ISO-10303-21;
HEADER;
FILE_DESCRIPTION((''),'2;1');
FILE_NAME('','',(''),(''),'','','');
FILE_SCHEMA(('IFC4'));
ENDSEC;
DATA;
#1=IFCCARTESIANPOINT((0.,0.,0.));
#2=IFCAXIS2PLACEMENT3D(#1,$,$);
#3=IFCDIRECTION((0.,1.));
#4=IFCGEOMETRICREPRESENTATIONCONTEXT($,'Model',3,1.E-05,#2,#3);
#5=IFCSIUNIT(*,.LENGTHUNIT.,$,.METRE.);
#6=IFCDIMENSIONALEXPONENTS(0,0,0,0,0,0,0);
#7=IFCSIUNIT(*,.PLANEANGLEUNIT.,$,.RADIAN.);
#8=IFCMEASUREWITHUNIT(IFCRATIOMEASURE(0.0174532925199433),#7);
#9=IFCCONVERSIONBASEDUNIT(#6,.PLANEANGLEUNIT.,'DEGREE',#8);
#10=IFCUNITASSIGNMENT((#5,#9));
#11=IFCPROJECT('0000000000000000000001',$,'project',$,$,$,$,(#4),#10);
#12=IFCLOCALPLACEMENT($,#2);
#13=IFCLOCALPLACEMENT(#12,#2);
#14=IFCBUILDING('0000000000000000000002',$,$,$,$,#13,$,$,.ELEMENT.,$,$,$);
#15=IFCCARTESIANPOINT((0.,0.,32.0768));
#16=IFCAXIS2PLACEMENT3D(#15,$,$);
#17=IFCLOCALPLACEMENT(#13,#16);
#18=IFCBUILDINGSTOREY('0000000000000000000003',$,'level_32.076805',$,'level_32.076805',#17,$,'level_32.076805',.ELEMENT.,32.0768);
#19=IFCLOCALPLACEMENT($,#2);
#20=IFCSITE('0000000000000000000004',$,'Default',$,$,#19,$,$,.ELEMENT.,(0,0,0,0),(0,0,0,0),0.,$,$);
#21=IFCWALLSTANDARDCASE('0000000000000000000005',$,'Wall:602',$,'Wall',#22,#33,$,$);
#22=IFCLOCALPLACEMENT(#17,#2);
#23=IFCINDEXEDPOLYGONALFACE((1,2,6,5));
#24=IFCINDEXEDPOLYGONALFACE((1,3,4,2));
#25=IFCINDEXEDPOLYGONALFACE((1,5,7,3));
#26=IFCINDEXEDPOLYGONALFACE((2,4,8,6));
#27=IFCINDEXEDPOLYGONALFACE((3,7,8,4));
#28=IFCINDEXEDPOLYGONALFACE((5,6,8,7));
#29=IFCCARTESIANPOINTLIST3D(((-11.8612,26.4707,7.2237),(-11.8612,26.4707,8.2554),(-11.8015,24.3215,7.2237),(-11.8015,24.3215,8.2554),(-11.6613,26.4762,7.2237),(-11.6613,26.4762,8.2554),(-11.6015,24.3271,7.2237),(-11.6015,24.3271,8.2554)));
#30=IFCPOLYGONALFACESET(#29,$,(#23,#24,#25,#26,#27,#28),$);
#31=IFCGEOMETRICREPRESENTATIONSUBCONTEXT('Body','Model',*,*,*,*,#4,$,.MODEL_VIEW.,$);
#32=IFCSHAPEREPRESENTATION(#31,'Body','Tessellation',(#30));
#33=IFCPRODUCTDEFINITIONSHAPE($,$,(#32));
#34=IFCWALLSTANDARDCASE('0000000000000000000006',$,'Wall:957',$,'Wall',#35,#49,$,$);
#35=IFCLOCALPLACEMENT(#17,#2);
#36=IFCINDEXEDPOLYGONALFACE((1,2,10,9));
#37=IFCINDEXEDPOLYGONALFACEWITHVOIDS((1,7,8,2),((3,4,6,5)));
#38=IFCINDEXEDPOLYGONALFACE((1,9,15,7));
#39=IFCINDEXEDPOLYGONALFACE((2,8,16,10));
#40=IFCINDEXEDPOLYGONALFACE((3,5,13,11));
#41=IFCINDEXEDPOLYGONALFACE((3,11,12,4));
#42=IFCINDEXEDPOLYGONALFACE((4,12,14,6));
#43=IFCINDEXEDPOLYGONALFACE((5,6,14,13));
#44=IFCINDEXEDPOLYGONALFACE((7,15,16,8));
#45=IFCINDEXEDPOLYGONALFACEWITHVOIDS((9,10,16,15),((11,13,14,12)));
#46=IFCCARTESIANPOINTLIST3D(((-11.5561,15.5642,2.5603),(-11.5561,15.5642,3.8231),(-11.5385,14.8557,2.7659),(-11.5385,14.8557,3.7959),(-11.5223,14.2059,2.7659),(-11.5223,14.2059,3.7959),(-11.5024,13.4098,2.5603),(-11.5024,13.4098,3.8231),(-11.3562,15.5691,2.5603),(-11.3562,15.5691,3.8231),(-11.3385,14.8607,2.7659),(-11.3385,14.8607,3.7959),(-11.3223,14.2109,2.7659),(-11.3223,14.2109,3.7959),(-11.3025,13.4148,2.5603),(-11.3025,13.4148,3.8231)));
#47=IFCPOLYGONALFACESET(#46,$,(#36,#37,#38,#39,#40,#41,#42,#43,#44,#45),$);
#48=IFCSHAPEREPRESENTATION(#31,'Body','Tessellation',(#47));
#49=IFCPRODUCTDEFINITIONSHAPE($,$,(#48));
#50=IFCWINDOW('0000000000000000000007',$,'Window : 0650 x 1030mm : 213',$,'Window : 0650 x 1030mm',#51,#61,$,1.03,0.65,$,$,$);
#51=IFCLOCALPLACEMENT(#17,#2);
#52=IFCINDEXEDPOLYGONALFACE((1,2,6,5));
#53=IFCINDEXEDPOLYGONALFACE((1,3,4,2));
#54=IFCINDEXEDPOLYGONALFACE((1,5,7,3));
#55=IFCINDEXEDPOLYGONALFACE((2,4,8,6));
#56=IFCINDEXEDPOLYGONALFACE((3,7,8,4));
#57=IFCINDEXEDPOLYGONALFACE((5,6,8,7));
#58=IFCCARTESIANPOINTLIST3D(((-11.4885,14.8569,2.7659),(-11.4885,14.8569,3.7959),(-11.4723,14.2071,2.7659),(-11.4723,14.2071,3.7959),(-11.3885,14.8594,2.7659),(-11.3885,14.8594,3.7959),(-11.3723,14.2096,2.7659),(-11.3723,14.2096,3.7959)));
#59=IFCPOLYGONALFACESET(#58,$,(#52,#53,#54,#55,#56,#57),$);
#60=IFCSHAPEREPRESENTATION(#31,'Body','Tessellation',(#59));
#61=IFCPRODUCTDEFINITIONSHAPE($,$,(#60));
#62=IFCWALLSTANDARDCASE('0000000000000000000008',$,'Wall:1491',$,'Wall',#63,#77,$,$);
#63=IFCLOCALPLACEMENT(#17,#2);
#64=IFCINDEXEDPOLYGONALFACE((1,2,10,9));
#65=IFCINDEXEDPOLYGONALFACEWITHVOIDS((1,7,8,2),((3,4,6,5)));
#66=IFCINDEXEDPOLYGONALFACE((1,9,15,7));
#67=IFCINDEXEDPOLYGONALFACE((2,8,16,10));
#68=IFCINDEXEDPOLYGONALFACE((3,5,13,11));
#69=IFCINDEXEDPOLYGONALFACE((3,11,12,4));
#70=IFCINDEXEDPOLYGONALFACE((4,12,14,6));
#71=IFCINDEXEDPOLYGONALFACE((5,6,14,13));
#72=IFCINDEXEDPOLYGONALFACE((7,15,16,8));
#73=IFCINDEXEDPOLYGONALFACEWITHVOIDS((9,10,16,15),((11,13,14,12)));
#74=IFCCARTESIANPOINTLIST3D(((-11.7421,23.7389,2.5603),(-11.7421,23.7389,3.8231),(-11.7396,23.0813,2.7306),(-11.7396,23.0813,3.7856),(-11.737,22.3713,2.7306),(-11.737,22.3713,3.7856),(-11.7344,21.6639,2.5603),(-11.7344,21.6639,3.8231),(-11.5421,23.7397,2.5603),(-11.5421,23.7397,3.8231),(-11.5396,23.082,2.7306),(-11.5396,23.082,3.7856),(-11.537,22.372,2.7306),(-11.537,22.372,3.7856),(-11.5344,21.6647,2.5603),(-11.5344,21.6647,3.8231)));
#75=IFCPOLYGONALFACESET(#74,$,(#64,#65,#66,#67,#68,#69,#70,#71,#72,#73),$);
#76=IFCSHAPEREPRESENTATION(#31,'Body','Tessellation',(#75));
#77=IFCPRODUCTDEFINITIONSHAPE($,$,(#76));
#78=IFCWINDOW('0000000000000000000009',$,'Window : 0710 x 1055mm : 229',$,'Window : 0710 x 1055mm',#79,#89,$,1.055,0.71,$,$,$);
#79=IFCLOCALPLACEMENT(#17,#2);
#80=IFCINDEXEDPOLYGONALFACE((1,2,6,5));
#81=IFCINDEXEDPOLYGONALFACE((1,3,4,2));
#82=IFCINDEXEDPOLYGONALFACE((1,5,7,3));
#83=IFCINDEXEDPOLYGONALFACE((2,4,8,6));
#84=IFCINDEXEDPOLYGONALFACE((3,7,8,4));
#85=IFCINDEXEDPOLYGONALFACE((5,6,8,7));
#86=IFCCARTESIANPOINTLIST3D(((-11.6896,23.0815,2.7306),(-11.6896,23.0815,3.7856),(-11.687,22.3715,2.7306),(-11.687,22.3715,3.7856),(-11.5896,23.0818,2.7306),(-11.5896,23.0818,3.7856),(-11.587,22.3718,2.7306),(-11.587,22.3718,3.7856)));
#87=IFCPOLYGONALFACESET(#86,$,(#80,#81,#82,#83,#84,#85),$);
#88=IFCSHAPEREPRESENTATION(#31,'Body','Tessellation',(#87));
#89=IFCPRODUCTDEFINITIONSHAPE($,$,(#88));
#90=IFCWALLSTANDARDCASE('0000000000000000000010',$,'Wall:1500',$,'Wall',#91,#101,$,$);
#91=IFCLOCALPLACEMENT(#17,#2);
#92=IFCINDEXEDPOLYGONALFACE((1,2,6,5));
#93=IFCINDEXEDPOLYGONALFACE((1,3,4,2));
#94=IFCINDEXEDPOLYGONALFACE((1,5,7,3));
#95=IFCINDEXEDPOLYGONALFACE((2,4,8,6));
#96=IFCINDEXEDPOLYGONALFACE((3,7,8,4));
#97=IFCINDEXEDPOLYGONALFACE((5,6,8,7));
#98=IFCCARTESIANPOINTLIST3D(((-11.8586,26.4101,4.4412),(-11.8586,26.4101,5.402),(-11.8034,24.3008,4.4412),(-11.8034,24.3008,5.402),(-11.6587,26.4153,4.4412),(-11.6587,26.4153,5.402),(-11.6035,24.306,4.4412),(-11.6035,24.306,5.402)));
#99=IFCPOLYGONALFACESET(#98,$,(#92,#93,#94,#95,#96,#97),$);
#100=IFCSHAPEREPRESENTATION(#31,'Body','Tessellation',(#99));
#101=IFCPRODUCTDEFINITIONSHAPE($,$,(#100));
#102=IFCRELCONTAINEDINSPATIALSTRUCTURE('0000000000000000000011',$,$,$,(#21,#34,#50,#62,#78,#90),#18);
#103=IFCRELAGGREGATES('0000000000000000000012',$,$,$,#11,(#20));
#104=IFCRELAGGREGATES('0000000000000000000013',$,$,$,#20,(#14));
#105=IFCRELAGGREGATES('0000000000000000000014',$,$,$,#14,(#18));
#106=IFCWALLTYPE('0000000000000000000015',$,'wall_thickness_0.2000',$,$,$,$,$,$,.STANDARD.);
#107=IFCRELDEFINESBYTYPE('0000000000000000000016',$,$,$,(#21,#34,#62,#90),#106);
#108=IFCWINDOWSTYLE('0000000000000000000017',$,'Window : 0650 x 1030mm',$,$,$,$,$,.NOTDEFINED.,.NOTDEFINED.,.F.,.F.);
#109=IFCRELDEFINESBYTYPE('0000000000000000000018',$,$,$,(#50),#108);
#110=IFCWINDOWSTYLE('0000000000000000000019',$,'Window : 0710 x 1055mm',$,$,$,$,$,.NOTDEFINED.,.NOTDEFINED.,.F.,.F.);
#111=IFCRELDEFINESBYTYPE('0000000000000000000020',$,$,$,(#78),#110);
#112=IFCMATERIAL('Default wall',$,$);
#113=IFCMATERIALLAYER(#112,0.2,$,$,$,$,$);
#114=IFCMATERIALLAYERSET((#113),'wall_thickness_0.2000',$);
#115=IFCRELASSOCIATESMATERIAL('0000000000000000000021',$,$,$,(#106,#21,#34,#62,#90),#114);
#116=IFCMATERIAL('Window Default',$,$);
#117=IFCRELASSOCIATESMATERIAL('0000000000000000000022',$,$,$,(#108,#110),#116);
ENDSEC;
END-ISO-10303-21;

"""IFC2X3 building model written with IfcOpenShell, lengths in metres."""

from ifc_helpers import new_model, entity, si_unit, converted_unit, direction, frame, frame_2d, origin, origin_2d_with_axis, place, context, subcontext, project, spatial, polyline, rectangle, outline, extrude, source, transform, mapped, material, layer, layer_set, layer_usage, type_object, type_shapes, element, fill, save


model = new_model("IFC2X3")

# Units and contexts
model_context = context("Model", 3, precision=1e-05, world=origin(), true_north=direction((0.0, 1.0)))
body_context = subcontext(model_context, "Body", "Model", "MODEL_VIEW")
ifc_project = project(units=[si_unit("LENGTHUNIT", "METRE"), converted_unit("PLANEANGLEUNIT", "DEGREE", entity("IfcRatioMeasure", 0.0174532925199433), si_unit("PLANEANGLEUNIT", "RADIAN"), dimensions=[0, 0, 0, 0, 0, 0, 0])], contexts=[model_context])

# Site, building, storey
site_placement = place(None, origin())
site = spatial("IfcSite", under=ifc_project, at=site_placement, Name="Default", CompositionType="ELEMENT", RefLatitude=(0, 0, 0, 0), RefLongitude=(0, 0, 0, 0), RefElevation=0.0)
placement_1 = place(None, origin())
building_placement = place(placement_1, origin())
building = spatial("IfcBuilding", under=site, at=building_placement, CompositionType="ELEMENT")
storey_placement = place(building_placement, frame((0.0, 0.0, 32.0768)))
storey = spatial("IfcBuildingStorey", under=building, at=storey_placement, Name="level_32.076805", ObjectType="level_32.076805", LongName="level_32.076805", CompositionType="ELEMENT", Elevation=32.0768)

# Shared definitions
ifc_material_1 = material(Name="Default wall")
ifc_layer = layer(ifc_material_1, 0.2)
ifc_layer_set = layer_set([ifc_layer], Name="wall_thickness_0.2000")
ifc_layer_usage = layer_usage(ifc_layer_set, "AXIS2", "POSITIVE", -0.1)
wall_type = type_object("IfcWallType", Name="wall_thickness_0.2000", PredefinedType="STANDARD", material=ifc_layer_set)
ifc_material_2 = material(Name="Window Default")

# Wall
placement_2 = place(building_placement, frame((0.0, 0.0, 39.3005)))
wall_1_placement = place(placement_2, frame((-11.7015, 24.3243, 0.0), z_axis=(0.0, 0.0, 1.0), x_axis=(-0.02778, 0.999614, 0.0)))
element("IfcWallStandardCase", 1, at=wall_1_placement, inside=storey, type_object=wall_type, material=ifc_layer_usage, Name="Wall:602", ObjectType="Wall", context=body_context, shape_type="SweptSolid", body=[
    extrude(outline(polyline([(2.15, -0.1), (2.15, 0.1), (0.0, 0.1), (0.0, -0.1), (2.15, -0.1)])), origin(), (0.0, 0.0, 1.0), 1.0317),
])

# Walls, openings, windows
placement_3 = place(building_placement, frame((0.0, 0.0, 34.6371)))
wall_2_placement = place(placement_3, frame((-11.4025, 13.4123, 0.0), z_axis=(0.0, 0.0, 1.0), x_axis=(-0.024917, 0.99969, 0.0)))
wall_2 = element("IfcWallStandardCase", 2, at=wall_2_placement, inside=storey, type_object=wall_type, material=ifc_layer_usage, Name="Wall:957", ObjectType="Wall", context=body_context, shape_type="SweptSolid", body=[
    extrude(outline(polyline([(2.155, -0.1), (2.155, 0.1), (0.0, 0.1), (0.0, -0.1), (2.155, -0.1)])), origin(), (0.0, 0.0, 1.0), 1.2628),
])
opening_1_placement = place(wall_2_placement, frame((0.7963, -0.1, 0.2056)))
opening_1 = element("IfcOpeningElement", 3, at=opening_1_placement, cuts=wall_2, ObjectType="Opening", context=body_context, shape_type="SweptSolid", body=[
    extrude(rectangle(XDim=0.65, YDim=1.03, at=frame_2d((0.515, 0.325), x_axis=(0.0, 1.0))), frame((0.0, 0.0, 0.0), z_axis=(0.0, 1.0, 0.0), x_axis=(0.0, 0.0, 1.0)), (0.0, 0.0, 1.0), 0.2),
])
window_style_1 = type_object("IfcWindowStyle", Name="Window : 0650 x 1030mm", ConstructionType="NOTDEFINED", OperationType="NOTDEFINED", ParameterTakesPrecedence=False, Sizeable=False, material=ifc_material_2)
shared_shape_1 = source(origin(), body_context, "Body", "SweptSolid", [
    extrude(rectangle(XDim=0.1, YDim=0.65, at=origin_2d_with_axis()), frame((0.325, 0.1, 0.0), z_axis=(0.0, 0.0, 1.0), x_axis=(0.0, 1.0, 0.0)), (0.0, 0.0, 1.0), 1.03),
])
type_shapes(window_style_1, [shared_shape_1])
window_1_placement = place(opening_1_placement, origin())
window_1 = element("IfcWindow", 4, at=window_1_placement, inside=storey, type_object=window_style_1, Name="Window : 0650 x 1030mm : 213", ObjectType="Window : 0650 x 1030mm", OverallHeight=1.03, OverallWidth=0.65, context=body_context, shape_type="MappedRepresentation", body=[
    mapped(shared_shape_1, transform((0.0, 0.0, 0.0), scale=1.0)),
])
fill(opening_1, window_1)
placement_4 = place(building_placement, frame((0.0, 0.0, 34.6371)))
wall_3_placement = place(placement_4, frame((-11.6421, 23.7393, 0.0), z_axis=(0.0, 0.0, 1.0), x_axis=(0.003714, -0.999993, 0.0)))
wall_3 = element("IfcWallStandardCase", 5, at=wall_3_placement, inside=storey, type_object=wall_type, material=ifc_layer_usage, Name="Wall:1491", ObjectType="Wall", context=body_context, shape_type="SweptSolid", body=[
    extrude(outline(polyline([(2.075, -0.1), (2.075, 0.1), (0.0, 0.1), (0.0, -0.1), (2.075, -0.1)])), origin(), (0.0, 0.0, 1.0), 1.2628),
])
opening_2_placement = place(wall_3_placement, frame((0.6576, -0.1, 0.1703)))
opening_2 = element("IfcOpeningElement", 6, at=opening_2_placement, cuts=wall_3, ObjectType="Opening", context=body_context, shape_type="SweptSolid", body=[
    extrude(rectangle(XDim=0.71, YDim=1.055, at=frame_2d((0.5275, 0.355), x_axis=(0.0, 1.0))), frame((0.0, 0.0, 0.0), z_axis=(0.0, 1.0, 0.0), x_axis=(0.0, 0.0, 1.0)), (0.0, 0.0, 1.0), 0.2),
])
window_style_2 = type_object("IfcWindowStyle", Name="Window : 0710 x 1055mm", ConstructionType="NOTDEFINED", OperationType="NOTDEFINED", ParameterTakesPrecedence=False, Sizeable=False, material=ifc_material_2)
shared_shape_2 = source(origin(), body_context, "Body", "SweptSolid", [
    extrude(rectangle(XDim=0.1, YDim=0.71, at=origin_2d_with_axis()), frame((0.355, 0.1, 0.0), z_axis=(0.0, 0.0, 1.0), x_axis=(0.0, 1.0, 0.0)), (0.0, 0.0, 1.0), 1.055),
])
type_shapes(window_style_2, [shared_shape_2])
window_2_placement = place(opening_2_placement, origin())
window_2 = element("IfcWindow", 7, at=window_2_placement, inside=storey, type_object=window_style_2, Name="Window : 0710 x 1055mm : 229", ObjectType="Window : 0710 x 1055mm", OverallHeight=1.055, OverallWidth=0.71, context=body_context, shape_type="MappedRepresentation", body=[
    mapped(shared_shape_2, transform((0.0, 0.0, 0.0), scale=1.0)),
])
fill(opening_2, window_2)

# Wall
placement_5 = place(building_placement, frame((0.0, 0.0, 36.518)))
wall_4_placement = place(placement_5, frame((-11.7586, 26.4127, 0.0), z_axis=(0.0, 0.0, 1.0), x_axis=(0.026158, -0.999658, 0.0)))
element("IfcWallStandardCase", 8, at=wall_4_placement, inside=storey, type_object=wall_type, material=ifc_layer_usage, Name="Wall:1500", ObjectType="Wall", context=body_context, shape_type="SweptSolid", body=[
    extrude(outline(polyline([(2.11, -0.1), (2.11, 0.1), (0.0, 0.1), (0.0, -0.1), (2.11, -0.1)])), origin(), (0.0, 0.0, 1.0), 0.9608),
])

save(model, "model.ifc")
